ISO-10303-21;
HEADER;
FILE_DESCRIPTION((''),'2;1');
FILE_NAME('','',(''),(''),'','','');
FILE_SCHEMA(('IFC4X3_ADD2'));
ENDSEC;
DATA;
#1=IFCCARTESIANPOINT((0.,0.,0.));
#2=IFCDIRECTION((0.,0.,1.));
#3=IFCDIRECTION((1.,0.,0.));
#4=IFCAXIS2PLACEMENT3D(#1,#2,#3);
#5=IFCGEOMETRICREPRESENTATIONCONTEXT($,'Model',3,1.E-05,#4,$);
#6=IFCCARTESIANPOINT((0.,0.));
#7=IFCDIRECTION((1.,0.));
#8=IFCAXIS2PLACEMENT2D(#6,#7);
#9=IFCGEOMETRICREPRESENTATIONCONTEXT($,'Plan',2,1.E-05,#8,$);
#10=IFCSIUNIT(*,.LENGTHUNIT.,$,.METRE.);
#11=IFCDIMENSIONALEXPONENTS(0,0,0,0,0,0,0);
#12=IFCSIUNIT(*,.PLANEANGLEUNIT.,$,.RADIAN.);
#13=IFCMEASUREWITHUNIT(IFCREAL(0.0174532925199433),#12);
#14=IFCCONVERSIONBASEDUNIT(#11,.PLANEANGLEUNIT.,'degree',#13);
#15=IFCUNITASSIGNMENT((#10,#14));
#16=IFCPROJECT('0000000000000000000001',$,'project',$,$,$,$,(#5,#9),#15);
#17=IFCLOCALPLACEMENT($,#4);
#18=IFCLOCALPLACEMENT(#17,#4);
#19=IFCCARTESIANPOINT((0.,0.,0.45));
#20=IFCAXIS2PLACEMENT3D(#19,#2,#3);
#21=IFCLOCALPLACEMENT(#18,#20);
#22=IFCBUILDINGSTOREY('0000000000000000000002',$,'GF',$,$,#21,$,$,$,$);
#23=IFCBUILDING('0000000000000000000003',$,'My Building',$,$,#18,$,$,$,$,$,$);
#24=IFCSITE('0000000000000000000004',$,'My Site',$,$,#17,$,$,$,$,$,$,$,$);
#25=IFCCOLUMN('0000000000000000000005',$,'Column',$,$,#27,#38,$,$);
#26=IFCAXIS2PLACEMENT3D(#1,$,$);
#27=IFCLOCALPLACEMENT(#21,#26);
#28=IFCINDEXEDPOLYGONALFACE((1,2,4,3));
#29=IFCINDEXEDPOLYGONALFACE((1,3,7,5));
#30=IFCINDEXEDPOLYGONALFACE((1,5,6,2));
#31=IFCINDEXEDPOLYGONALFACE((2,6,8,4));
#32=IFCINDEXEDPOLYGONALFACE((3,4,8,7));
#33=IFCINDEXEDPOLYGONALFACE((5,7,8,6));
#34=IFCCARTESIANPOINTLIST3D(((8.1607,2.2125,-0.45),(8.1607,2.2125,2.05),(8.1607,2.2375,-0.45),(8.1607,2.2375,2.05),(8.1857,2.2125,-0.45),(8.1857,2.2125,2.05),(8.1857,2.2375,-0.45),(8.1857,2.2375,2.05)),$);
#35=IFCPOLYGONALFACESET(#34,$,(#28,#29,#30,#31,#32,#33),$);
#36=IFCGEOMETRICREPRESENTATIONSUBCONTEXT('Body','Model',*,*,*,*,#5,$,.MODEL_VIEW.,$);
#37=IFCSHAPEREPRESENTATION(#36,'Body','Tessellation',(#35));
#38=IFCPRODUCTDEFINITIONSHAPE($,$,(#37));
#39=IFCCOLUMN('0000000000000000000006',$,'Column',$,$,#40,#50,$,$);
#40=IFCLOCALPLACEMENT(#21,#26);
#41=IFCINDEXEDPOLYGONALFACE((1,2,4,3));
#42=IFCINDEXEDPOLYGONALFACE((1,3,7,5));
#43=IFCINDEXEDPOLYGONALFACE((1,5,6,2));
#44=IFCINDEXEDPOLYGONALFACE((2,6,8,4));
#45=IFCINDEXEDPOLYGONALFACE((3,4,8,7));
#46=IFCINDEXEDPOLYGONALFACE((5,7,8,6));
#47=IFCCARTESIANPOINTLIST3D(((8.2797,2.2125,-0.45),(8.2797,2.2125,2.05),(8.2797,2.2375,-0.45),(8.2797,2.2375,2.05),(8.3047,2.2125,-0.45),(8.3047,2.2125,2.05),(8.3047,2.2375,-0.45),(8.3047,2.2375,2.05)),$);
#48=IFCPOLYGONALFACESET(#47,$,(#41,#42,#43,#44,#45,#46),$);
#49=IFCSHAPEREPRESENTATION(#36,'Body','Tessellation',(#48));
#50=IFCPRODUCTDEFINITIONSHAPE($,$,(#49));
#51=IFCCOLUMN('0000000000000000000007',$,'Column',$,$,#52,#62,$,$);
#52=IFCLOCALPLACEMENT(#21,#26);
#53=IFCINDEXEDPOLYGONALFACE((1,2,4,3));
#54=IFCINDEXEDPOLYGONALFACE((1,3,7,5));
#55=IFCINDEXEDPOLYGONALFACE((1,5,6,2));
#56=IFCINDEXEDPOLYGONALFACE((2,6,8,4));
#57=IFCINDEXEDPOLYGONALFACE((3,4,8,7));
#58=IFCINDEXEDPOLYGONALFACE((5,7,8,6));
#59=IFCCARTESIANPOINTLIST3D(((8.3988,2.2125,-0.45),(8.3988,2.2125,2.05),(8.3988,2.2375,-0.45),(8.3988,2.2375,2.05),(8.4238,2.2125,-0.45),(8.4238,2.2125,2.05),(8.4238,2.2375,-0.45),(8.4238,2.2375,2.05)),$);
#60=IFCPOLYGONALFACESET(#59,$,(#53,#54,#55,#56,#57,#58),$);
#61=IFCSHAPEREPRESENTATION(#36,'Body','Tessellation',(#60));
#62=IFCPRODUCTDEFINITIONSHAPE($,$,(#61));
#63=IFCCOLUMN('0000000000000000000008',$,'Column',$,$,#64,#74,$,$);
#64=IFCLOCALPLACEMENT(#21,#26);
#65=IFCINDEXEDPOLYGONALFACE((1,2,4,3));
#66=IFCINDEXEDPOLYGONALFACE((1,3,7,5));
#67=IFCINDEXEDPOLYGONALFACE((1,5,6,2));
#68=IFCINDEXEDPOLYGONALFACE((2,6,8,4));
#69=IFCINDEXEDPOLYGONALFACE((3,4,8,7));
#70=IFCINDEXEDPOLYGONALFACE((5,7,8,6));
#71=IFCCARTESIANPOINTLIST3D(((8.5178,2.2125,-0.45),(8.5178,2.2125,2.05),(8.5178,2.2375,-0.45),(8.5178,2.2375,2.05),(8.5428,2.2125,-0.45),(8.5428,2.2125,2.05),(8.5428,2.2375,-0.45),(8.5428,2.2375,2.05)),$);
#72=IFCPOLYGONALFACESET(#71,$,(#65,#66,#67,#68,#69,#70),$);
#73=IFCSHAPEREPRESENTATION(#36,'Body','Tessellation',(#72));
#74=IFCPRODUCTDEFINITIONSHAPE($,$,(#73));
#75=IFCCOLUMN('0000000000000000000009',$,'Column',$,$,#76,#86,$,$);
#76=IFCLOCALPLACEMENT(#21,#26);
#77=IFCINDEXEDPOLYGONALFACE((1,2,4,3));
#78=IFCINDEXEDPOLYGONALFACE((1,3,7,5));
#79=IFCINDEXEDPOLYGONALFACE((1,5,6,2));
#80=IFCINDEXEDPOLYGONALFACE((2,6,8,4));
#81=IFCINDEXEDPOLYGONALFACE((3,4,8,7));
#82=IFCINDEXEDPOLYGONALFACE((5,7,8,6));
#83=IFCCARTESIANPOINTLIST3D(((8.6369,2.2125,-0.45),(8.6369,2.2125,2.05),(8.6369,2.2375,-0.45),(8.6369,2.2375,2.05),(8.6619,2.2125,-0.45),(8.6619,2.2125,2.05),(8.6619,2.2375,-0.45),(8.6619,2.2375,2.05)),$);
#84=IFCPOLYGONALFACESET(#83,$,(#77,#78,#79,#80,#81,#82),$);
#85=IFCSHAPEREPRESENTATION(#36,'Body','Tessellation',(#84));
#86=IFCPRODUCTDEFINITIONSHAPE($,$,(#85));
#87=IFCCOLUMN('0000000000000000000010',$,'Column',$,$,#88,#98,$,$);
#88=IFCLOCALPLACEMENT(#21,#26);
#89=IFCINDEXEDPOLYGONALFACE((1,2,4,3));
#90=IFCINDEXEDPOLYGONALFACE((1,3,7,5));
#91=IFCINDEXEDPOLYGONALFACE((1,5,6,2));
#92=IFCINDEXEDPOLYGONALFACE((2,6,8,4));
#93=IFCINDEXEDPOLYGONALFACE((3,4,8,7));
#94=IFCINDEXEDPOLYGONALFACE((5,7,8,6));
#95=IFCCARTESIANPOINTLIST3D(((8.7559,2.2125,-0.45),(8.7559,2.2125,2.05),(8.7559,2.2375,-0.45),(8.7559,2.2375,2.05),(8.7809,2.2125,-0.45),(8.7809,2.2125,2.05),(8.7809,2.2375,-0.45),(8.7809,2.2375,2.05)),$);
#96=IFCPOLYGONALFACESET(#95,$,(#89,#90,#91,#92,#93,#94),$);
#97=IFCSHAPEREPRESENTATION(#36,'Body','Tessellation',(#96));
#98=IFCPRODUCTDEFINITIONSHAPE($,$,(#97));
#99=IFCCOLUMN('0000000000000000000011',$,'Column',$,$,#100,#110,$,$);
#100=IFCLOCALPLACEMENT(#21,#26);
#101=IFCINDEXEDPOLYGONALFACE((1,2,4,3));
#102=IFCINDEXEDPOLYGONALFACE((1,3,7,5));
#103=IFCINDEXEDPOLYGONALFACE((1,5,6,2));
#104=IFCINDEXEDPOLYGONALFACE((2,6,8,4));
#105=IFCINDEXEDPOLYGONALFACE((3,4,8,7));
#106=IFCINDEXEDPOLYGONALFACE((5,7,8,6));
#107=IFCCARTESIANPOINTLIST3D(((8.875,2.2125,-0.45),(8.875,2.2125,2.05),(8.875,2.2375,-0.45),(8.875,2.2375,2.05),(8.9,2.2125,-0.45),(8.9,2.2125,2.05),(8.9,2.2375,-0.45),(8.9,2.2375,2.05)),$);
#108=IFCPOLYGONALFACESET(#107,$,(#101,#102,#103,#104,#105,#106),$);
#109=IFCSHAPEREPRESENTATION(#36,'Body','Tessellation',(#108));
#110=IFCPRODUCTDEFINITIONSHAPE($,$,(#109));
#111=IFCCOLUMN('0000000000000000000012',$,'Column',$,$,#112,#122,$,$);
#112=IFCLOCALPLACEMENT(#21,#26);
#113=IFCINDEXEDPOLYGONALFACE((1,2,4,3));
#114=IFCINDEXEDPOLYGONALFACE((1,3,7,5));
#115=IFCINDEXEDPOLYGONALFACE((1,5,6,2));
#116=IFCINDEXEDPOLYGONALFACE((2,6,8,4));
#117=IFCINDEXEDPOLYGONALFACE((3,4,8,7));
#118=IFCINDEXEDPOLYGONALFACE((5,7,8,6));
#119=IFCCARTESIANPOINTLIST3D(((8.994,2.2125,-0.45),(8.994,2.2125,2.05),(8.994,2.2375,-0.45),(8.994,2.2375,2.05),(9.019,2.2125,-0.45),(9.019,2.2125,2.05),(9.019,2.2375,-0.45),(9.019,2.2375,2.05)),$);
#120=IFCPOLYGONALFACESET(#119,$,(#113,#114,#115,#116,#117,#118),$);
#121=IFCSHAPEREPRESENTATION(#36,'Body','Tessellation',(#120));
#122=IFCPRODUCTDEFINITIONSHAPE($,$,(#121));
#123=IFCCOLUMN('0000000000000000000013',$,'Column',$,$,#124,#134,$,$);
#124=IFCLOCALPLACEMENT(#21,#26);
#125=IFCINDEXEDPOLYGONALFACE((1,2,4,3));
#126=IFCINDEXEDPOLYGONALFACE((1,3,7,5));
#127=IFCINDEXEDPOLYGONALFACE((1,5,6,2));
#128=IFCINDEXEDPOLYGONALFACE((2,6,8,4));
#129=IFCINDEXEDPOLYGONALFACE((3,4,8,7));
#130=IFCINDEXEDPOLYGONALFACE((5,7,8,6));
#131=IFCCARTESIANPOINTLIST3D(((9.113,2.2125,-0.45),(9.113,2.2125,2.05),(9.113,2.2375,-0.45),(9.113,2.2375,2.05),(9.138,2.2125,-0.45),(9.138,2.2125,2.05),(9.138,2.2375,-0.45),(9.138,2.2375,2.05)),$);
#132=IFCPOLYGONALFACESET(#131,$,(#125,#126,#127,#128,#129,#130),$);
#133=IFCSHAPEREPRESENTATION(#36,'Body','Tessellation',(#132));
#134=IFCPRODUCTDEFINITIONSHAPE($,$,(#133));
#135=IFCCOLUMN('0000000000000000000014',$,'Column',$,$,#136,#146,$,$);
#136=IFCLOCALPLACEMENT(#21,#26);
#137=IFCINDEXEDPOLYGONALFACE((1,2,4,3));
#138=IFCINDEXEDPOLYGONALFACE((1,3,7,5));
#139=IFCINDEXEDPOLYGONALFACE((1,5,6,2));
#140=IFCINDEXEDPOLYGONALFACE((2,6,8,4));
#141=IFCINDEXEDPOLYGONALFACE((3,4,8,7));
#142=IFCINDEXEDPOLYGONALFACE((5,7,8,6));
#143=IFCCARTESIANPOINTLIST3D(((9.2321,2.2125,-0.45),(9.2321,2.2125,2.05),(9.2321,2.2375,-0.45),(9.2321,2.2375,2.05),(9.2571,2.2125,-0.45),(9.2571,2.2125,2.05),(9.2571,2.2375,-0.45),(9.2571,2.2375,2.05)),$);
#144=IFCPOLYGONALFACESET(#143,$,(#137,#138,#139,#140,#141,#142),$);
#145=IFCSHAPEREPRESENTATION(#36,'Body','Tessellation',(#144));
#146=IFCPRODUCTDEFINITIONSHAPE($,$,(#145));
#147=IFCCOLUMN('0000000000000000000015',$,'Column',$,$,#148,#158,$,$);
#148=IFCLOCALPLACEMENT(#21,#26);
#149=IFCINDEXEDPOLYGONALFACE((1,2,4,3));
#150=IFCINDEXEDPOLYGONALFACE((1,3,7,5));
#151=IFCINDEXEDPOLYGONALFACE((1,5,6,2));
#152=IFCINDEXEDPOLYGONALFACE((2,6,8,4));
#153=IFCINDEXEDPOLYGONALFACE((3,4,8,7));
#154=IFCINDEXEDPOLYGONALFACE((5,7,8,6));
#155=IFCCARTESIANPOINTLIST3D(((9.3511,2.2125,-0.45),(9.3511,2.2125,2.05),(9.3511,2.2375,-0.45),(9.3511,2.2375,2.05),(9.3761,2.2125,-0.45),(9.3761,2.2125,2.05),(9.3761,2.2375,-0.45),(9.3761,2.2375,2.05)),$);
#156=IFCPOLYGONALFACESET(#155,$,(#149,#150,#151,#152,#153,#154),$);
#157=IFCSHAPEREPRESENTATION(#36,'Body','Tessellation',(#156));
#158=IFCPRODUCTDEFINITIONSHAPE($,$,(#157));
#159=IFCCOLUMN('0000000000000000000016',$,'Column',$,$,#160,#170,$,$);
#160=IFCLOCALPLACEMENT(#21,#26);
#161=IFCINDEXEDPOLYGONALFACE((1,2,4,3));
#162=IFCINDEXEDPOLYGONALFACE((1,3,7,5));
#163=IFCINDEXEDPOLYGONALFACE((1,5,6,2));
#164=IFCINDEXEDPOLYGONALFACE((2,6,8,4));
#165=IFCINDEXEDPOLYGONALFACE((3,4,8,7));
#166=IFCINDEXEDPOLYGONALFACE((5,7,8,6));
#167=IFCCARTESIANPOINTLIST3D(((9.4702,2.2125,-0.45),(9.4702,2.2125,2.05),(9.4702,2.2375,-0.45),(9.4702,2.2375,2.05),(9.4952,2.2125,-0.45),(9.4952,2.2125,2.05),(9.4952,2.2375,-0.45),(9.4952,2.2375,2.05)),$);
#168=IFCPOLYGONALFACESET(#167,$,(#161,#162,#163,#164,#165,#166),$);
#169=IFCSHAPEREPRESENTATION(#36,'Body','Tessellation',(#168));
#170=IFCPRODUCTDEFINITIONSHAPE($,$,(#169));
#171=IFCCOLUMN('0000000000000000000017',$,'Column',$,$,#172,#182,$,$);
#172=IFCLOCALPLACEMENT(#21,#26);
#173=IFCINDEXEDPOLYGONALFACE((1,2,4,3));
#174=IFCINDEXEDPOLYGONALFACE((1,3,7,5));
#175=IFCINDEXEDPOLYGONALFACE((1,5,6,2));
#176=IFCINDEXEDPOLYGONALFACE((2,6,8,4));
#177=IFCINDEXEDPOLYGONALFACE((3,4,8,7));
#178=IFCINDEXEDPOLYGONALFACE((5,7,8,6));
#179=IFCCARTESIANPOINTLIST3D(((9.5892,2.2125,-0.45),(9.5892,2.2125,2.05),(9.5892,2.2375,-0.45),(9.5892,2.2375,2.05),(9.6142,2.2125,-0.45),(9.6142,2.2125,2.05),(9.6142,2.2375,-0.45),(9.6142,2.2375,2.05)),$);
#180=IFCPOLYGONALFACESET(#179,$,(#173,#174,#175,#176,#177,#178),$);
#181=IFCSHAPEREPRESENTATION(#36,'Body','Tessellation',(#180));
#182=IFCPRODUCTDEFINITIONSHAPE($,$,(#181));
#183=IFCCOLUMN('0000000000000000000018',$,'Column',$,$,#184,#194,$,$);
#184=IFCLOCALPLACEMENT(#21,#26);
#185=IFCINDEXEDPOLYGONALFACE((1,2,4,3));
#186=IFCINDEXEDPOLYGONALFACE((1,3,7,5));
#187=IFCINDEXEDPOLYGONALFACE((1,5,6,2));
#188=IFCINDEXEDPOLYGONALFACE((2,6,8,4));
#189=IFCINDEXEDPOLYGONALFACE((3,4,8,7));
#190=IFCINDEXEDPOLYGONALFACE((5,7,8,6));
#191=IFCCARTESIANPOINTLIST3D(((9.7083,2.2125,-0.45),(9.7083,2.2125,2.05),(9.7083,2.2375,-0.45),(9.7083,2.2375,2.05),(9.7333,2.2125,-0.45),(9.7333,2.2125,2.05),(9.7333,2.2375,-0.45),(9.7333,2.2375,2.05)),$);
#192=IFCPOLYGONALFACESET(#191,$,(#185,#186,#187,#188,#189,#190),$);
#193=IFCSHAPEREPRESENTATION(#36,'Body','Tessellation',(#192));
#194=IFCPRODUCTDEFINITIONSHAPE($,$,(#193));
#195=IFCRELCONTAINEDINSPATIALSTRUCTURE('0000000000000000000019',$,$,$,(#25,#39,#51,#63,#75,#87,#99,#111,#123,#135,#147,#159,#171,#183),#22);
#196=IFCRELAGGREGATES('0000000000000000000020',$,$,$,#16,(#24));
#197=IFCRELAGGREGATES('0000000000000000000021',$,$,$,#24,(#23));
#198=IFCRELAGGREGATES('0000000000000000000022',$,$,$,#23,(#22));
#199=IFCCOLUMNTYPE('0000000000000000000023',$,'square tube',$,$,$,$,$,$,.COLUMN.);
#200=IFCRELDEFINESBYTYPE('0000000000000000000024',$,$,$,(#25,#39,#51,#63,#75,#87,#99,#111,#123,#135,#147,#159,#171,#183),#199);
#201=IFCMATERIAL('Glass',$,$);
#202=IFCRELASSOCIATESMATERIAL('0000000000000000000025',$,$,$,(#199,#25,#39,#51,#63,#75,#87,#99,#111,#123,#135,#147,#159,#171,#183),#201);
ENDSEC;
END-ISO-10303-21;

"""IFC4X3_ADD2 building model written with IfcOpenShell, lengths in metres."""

from ifc_helpers import new_model, entity, si_unit, converted_unit, frame, origin_with_axes, origin_2d_with_axis, place, context, subcontext, project, spatial, rectangle, extrude, material, material_profile, profile_set, profile_usage, type_object, element, save


model = new_model("IFC4X3_ADD2")

# Units and contexts
model_context = context("Model", 3, precision=1e-05, world=origin_with_axes())
plan_context = context("Plan", 2, precision=1e-05, world=origin_2d_with_axis())
body_context_1 = subcontext(model_context, "Body", "Model", "MODEL_VIEW")
ifc_project = project(units=[si_unit("LENGTHUNIT", "METRE"), converted_unit("PLANEANGLEUNIT", "degree", entity("IfcReal", 0.0174532925199433), si_unit("PLANEANGLEUNIT", "RADIAN"), dimensions=[0, 0, 0, 0, 0, 0, 0])], contexts=[model_context, plan_context])

# Site, building, storey
site_placement = place(None, origin_with_axes())
site = spatial("IfcSite", under=ifc_project, at=site_placement, Name="My Site")
building_placement = place(site_placement, origin_with_axes())
building = spatial("IfcBuilding", under=site, at=building_placement, Name="My Building")
storey_placement = place(building_placement, frame((0.0, 0.0, 0.45), z_axis=(0.0, 0.0, 1.0), x_axis=(1.0, 0.0, 0.0)))
storey = spatial("IfcBuildingStorey", under=building, at=storey_placement, Name="GF")

# Columns
ifc_material_1 = material(Name="Glass")
ifc_material_profile = material_profile(ifc_material_1, rectangle(XDim=0.025, YDim=0.025))
ifc_profile_set = profile_set([ifc_material_profile])
ifc_profile_usage_1 = profile_usage(ifc_profile_set, cardinal=5)
column_type = type_object("IfcColumnType", Name="square tube", PredefinedType="COLUMN", material=ifc_profile_set)
column_1_placement = place(storey_placement, frame((8.1732, 2.225, -0.45), z_axis=(0.0, 0.0, 1.0), x_axis=(1.0, 0.0, 0.0)))
element("IfcColumn", 1, at=column_1_placement, inside=storey, type_object=column_type, material=ifc_profile_usage_1, Name="Column", context=body_context_1, shape_type="SweptSolid", body=[
    extrude(rectangle(XDim=0.025, YDim=0.025), origin_with_axes(), (0.0, 0.0, 1.0), 2.5),
])
ifc_profile_usage_2 = profile_usage(ifc_profile_set, cardinal=5)
column_2_placement = place(storey_placement, frame((8.2922, 2.225, -0.45), z_axis=(0.0, 0.0, 1.0), x_axis=(1.0, 0.0, 0.0)))
element("IfcColumn", 2, at=column_2_placement, inside=storey, type_object=column_type, material=ifc_profile_usage_2, Name="Column", context=body_context_1, shape_type="SweptSolid", body=[
    extrude(rectangle(XDim=0.025, YDim=0.025), origin_with_axes(), (0.0, 0.0, 1.0), 2.5),
])
ifc_profile_usage_3 = profile_usage(ifc_profile_set, cardinal=5)
column_3_placement = place(storey_placement, frame((8.4113, 2.225, -0.45), z_axis=(0.0, 0.0, 1.0), x_axis=(1.0, 0.0, 0.0)))
element("IfcColumn", 3, at=column_3_placement, inside=storey, type_object=column_type, material=ifc_profile_usage_3, Name="Column", context=body_context_1, shape_type="SweptSolid", body=[
    extrude(rectangle(XDim=0.025, YDim=0.025), origin_with_axes(), (0.0, 0.0, 1.0), 2.5),
])
ifc_profile_usage_4 = profile_usage(ifc_profile_set, cardinal=5)
column_4_placement = place(storey_placement, frame((8.5303, 2.225, -0.45), z_axis=(0.0, 0.0, 1.0), x_axis=(1.0, 0.0, 0.0)))
element("IfcColumn", 4, at=column_4_placement, inside=storey, type_object=column_type, material=ifc_profile_usage_4, Name="Column", context=body_context_1, shape_type="SweptSolid", body=[
    extrude(rectangle(XDim=0.025, YDim=0.025), origin_with_axes(), (0.0, 0.0, 1.0), 2.5),
])
ifc_profile_usage_5 = profile_usage(ifc_profile_set, cardinal=5)
column_5_placement = place(storey_placement, frame((8.6494, 2.225, -0.45), z_axis=(0.0, 0.0, 1.0), x_axis=(1.0, 0.0, 0.0)))
element("IfcColumn", 5, at=column_5_placement, inside=storey, type_object=column_type, material=ifc_profile_usage_5, Name="Column", context=body_context_1, shape_type="SweptSolid", body=[
    extrude(rectangle(XDim=0.025, YDim=0.025), origin_with_axes(), (0.0, 0.0, 1.0), 2.5),
])
ifc_profile_usage_6 = profile_usage(ifc_profile_set, cardinal=5)
column_6_placement = place(storey_placement, frame((8.7684, 2.225, -0.45), z_axis=(0.0, 0.0, 1.0), x_axis=(1.0, 0.0, 0.0)))
element("IfcColumn", 6, at=column_6_placement, inside=storey, type_object=column_type, material=ifc_profile_usage_6, Name="Column", context=body_context_1, shape_type="SweptSolid", body=[
    extrude(rectangle(XDim=0.025, YDim=0.025), origin_with_axes(), (0.0, 0.0, 1.0), 2.5),
])
ifc_profile_usage_7 = profile_usage(ifc_profile_set, cardinal=5)
column_7_placement = place(storey_placement, frame((8.8875, 2.225, -0.45), z_axis=(0.0, 0.0, 1.0), x_axis=(1.0, 0.0, 0.0)))
element("IfcColumn", 7, at=column_7_placement, inside=storey, type_object=column_type, material=ifc_profile_usage_7, Name="Column", context=body_context_1, shape_type="SweptSolid", body=[
    extrude(rectangle(XDim=0.025, YDim=0.025), origin_with_axes(), (0.0, 0.0, 1.0), 2.5),
])
ifc_profile_usage_8 = profile_usage(ifc_profile_set, cardinal=5)
column_8_placement = place(storey_placement, frame((9.0065, 2.225, -0.45), z_axis=(0.0, 0.0, 1.0), x_axis=(1.0, 0.0, 0.0)))
element("IfcColumn", 8, at=column_8_placement, inside=storey, type_object=column_type, material=ifc_profile_usage_8, Name="Column", context=body_context_1, shape_type="SweptSolid", body=[
    extrude(rectangle(XDim=0.025, YDim=0.025), origin_with_axes(), (0.0, 0.0, 1.0), 2.5),
])
ifc_profile_usage_9 = profile_usage(ifc_profile_set, cardinal=5)
column_9_placement = place(storey_placement, frame((9.1255, 2.225, -0.45), z_axis=(0.0, 0.0, 1.0), x_axis=(1.0, 0.0, 0.0)))
element("IfcColumn", 9, at=column_9_placement, inside=storey, type_object=column_type, material=ifc_profile_usage_9, Name="Column", context=body_context_1, shape_type="SweptSolid", body=[
    extrude(rectangle(XDim=0.025, YDim=0.025), origin_with_axes(), (0.0, 0.0, 1.0), 2.5),
])
ifc_profile_usage_10 = profile_usage(ifc_profile_set, cardinal=5)
column_10_placement = place(storey_placement, frame((9.2446, 2.225, -0.45), z_axis=(0.0, 0.0, 1.0), x_axis=(1.0, 0.0, 0.0)))
element("IfcColumn", 10, at=column_10_placement, inside=storey, type_object=column_type, material=ifc_profile_usage_10, Name="Column", context=body_context_1, shape_type="SweptSolid", body=[
    extrude(rectangle(XDim=0.025, YDim=0.025), origin_with_axes(), (0.0, 0.0, 1.0), 2.5),
])
ifc_profile_usage_11 = profile_usage(ifc_profile_set, cardinal=5)
column_11_placement = place(storey_placement, frame((9.3636, 2.225, -0.45), z_axis=(0.0, 0.0, 1.0), x_axis=(1.0, 0.0, 0.0)))
element("IfcColumn", 11, at=column_11_placement, inside=storey, type_object=column_type, material=ifc_profile_usage_11, Name="Column", context=body_context_1, shape_type="SweptSolid", body=[
    extrude(rectangle(XDim=0.025, YDim=0.025), origin_with_axes(), (0.0, 0.0, 1.0), 2.5),
])
ifc_profile_usage_12 = profile_usage(ifc_profile_set, cardinal=5)
column_12_placement = place(storey_placement, frame((9.4827, 2.225, -0.45), z_axis=(0.0, 0.0, 1.0), x_axis=(1.0, 0.0, 0.0)))
element("IfcColumn", 12, at=column_12_placement, inside=storey, type_object=column_type, material=ifc_profile_usage_12, Name="Column", context=body_context_1, shape_type="SweptSolid", body=[
    extrude(rectangle(XDim=0.025, YDim=0.025), origin_with_axes(), (0.0, 0.0, 1.0), 2.5),
])
ifc_profile_usage_13 = profile_usage(ifc_profile_set, cardinal=5)
column_13_placement = place(storey_placement, frame((9.6017, 2.225, -0.45), z_axis=(0.0, 0.0, 1.0), x_axis=(1.0, 0.0, 0.0)))
element("IfcColumn", 13, at=column_13_placement, inside=storey, type_object=column_type, material=ifc_profile_usage_13, Name="Column", context=body_context_1, shape_type="SweptSolid", body=[
    extrude(rectangle(XDim=0.025, YDim=0.025), origin_with_axes(), (0.0, 0.0, 1.0), 2.5),
])
ifc_profile_usage_14 = profile_usage(ifc_profile_set, cardinal=5)
column_14_placement = place(storey_placement, frame((9.7208, 2.225, -0.45), z_axis=(0.0, 0.0, 1.0), x_axis=(1.0, 0.0, 0.0)))
element("IfcColumn", 14, at=column_14_placement, inside=storey, type_object=column_type, material=ifc_profile_usage_14, Name="Column", context=body_context_1, shape_type="SweptSolid", body=[
    extrude(rectangle(XDim=0.025, YDim=0.025), origin_with_axes(), (0.0, 0.0, 1.0), 2.5),
])

save(model, "model.ifc")
